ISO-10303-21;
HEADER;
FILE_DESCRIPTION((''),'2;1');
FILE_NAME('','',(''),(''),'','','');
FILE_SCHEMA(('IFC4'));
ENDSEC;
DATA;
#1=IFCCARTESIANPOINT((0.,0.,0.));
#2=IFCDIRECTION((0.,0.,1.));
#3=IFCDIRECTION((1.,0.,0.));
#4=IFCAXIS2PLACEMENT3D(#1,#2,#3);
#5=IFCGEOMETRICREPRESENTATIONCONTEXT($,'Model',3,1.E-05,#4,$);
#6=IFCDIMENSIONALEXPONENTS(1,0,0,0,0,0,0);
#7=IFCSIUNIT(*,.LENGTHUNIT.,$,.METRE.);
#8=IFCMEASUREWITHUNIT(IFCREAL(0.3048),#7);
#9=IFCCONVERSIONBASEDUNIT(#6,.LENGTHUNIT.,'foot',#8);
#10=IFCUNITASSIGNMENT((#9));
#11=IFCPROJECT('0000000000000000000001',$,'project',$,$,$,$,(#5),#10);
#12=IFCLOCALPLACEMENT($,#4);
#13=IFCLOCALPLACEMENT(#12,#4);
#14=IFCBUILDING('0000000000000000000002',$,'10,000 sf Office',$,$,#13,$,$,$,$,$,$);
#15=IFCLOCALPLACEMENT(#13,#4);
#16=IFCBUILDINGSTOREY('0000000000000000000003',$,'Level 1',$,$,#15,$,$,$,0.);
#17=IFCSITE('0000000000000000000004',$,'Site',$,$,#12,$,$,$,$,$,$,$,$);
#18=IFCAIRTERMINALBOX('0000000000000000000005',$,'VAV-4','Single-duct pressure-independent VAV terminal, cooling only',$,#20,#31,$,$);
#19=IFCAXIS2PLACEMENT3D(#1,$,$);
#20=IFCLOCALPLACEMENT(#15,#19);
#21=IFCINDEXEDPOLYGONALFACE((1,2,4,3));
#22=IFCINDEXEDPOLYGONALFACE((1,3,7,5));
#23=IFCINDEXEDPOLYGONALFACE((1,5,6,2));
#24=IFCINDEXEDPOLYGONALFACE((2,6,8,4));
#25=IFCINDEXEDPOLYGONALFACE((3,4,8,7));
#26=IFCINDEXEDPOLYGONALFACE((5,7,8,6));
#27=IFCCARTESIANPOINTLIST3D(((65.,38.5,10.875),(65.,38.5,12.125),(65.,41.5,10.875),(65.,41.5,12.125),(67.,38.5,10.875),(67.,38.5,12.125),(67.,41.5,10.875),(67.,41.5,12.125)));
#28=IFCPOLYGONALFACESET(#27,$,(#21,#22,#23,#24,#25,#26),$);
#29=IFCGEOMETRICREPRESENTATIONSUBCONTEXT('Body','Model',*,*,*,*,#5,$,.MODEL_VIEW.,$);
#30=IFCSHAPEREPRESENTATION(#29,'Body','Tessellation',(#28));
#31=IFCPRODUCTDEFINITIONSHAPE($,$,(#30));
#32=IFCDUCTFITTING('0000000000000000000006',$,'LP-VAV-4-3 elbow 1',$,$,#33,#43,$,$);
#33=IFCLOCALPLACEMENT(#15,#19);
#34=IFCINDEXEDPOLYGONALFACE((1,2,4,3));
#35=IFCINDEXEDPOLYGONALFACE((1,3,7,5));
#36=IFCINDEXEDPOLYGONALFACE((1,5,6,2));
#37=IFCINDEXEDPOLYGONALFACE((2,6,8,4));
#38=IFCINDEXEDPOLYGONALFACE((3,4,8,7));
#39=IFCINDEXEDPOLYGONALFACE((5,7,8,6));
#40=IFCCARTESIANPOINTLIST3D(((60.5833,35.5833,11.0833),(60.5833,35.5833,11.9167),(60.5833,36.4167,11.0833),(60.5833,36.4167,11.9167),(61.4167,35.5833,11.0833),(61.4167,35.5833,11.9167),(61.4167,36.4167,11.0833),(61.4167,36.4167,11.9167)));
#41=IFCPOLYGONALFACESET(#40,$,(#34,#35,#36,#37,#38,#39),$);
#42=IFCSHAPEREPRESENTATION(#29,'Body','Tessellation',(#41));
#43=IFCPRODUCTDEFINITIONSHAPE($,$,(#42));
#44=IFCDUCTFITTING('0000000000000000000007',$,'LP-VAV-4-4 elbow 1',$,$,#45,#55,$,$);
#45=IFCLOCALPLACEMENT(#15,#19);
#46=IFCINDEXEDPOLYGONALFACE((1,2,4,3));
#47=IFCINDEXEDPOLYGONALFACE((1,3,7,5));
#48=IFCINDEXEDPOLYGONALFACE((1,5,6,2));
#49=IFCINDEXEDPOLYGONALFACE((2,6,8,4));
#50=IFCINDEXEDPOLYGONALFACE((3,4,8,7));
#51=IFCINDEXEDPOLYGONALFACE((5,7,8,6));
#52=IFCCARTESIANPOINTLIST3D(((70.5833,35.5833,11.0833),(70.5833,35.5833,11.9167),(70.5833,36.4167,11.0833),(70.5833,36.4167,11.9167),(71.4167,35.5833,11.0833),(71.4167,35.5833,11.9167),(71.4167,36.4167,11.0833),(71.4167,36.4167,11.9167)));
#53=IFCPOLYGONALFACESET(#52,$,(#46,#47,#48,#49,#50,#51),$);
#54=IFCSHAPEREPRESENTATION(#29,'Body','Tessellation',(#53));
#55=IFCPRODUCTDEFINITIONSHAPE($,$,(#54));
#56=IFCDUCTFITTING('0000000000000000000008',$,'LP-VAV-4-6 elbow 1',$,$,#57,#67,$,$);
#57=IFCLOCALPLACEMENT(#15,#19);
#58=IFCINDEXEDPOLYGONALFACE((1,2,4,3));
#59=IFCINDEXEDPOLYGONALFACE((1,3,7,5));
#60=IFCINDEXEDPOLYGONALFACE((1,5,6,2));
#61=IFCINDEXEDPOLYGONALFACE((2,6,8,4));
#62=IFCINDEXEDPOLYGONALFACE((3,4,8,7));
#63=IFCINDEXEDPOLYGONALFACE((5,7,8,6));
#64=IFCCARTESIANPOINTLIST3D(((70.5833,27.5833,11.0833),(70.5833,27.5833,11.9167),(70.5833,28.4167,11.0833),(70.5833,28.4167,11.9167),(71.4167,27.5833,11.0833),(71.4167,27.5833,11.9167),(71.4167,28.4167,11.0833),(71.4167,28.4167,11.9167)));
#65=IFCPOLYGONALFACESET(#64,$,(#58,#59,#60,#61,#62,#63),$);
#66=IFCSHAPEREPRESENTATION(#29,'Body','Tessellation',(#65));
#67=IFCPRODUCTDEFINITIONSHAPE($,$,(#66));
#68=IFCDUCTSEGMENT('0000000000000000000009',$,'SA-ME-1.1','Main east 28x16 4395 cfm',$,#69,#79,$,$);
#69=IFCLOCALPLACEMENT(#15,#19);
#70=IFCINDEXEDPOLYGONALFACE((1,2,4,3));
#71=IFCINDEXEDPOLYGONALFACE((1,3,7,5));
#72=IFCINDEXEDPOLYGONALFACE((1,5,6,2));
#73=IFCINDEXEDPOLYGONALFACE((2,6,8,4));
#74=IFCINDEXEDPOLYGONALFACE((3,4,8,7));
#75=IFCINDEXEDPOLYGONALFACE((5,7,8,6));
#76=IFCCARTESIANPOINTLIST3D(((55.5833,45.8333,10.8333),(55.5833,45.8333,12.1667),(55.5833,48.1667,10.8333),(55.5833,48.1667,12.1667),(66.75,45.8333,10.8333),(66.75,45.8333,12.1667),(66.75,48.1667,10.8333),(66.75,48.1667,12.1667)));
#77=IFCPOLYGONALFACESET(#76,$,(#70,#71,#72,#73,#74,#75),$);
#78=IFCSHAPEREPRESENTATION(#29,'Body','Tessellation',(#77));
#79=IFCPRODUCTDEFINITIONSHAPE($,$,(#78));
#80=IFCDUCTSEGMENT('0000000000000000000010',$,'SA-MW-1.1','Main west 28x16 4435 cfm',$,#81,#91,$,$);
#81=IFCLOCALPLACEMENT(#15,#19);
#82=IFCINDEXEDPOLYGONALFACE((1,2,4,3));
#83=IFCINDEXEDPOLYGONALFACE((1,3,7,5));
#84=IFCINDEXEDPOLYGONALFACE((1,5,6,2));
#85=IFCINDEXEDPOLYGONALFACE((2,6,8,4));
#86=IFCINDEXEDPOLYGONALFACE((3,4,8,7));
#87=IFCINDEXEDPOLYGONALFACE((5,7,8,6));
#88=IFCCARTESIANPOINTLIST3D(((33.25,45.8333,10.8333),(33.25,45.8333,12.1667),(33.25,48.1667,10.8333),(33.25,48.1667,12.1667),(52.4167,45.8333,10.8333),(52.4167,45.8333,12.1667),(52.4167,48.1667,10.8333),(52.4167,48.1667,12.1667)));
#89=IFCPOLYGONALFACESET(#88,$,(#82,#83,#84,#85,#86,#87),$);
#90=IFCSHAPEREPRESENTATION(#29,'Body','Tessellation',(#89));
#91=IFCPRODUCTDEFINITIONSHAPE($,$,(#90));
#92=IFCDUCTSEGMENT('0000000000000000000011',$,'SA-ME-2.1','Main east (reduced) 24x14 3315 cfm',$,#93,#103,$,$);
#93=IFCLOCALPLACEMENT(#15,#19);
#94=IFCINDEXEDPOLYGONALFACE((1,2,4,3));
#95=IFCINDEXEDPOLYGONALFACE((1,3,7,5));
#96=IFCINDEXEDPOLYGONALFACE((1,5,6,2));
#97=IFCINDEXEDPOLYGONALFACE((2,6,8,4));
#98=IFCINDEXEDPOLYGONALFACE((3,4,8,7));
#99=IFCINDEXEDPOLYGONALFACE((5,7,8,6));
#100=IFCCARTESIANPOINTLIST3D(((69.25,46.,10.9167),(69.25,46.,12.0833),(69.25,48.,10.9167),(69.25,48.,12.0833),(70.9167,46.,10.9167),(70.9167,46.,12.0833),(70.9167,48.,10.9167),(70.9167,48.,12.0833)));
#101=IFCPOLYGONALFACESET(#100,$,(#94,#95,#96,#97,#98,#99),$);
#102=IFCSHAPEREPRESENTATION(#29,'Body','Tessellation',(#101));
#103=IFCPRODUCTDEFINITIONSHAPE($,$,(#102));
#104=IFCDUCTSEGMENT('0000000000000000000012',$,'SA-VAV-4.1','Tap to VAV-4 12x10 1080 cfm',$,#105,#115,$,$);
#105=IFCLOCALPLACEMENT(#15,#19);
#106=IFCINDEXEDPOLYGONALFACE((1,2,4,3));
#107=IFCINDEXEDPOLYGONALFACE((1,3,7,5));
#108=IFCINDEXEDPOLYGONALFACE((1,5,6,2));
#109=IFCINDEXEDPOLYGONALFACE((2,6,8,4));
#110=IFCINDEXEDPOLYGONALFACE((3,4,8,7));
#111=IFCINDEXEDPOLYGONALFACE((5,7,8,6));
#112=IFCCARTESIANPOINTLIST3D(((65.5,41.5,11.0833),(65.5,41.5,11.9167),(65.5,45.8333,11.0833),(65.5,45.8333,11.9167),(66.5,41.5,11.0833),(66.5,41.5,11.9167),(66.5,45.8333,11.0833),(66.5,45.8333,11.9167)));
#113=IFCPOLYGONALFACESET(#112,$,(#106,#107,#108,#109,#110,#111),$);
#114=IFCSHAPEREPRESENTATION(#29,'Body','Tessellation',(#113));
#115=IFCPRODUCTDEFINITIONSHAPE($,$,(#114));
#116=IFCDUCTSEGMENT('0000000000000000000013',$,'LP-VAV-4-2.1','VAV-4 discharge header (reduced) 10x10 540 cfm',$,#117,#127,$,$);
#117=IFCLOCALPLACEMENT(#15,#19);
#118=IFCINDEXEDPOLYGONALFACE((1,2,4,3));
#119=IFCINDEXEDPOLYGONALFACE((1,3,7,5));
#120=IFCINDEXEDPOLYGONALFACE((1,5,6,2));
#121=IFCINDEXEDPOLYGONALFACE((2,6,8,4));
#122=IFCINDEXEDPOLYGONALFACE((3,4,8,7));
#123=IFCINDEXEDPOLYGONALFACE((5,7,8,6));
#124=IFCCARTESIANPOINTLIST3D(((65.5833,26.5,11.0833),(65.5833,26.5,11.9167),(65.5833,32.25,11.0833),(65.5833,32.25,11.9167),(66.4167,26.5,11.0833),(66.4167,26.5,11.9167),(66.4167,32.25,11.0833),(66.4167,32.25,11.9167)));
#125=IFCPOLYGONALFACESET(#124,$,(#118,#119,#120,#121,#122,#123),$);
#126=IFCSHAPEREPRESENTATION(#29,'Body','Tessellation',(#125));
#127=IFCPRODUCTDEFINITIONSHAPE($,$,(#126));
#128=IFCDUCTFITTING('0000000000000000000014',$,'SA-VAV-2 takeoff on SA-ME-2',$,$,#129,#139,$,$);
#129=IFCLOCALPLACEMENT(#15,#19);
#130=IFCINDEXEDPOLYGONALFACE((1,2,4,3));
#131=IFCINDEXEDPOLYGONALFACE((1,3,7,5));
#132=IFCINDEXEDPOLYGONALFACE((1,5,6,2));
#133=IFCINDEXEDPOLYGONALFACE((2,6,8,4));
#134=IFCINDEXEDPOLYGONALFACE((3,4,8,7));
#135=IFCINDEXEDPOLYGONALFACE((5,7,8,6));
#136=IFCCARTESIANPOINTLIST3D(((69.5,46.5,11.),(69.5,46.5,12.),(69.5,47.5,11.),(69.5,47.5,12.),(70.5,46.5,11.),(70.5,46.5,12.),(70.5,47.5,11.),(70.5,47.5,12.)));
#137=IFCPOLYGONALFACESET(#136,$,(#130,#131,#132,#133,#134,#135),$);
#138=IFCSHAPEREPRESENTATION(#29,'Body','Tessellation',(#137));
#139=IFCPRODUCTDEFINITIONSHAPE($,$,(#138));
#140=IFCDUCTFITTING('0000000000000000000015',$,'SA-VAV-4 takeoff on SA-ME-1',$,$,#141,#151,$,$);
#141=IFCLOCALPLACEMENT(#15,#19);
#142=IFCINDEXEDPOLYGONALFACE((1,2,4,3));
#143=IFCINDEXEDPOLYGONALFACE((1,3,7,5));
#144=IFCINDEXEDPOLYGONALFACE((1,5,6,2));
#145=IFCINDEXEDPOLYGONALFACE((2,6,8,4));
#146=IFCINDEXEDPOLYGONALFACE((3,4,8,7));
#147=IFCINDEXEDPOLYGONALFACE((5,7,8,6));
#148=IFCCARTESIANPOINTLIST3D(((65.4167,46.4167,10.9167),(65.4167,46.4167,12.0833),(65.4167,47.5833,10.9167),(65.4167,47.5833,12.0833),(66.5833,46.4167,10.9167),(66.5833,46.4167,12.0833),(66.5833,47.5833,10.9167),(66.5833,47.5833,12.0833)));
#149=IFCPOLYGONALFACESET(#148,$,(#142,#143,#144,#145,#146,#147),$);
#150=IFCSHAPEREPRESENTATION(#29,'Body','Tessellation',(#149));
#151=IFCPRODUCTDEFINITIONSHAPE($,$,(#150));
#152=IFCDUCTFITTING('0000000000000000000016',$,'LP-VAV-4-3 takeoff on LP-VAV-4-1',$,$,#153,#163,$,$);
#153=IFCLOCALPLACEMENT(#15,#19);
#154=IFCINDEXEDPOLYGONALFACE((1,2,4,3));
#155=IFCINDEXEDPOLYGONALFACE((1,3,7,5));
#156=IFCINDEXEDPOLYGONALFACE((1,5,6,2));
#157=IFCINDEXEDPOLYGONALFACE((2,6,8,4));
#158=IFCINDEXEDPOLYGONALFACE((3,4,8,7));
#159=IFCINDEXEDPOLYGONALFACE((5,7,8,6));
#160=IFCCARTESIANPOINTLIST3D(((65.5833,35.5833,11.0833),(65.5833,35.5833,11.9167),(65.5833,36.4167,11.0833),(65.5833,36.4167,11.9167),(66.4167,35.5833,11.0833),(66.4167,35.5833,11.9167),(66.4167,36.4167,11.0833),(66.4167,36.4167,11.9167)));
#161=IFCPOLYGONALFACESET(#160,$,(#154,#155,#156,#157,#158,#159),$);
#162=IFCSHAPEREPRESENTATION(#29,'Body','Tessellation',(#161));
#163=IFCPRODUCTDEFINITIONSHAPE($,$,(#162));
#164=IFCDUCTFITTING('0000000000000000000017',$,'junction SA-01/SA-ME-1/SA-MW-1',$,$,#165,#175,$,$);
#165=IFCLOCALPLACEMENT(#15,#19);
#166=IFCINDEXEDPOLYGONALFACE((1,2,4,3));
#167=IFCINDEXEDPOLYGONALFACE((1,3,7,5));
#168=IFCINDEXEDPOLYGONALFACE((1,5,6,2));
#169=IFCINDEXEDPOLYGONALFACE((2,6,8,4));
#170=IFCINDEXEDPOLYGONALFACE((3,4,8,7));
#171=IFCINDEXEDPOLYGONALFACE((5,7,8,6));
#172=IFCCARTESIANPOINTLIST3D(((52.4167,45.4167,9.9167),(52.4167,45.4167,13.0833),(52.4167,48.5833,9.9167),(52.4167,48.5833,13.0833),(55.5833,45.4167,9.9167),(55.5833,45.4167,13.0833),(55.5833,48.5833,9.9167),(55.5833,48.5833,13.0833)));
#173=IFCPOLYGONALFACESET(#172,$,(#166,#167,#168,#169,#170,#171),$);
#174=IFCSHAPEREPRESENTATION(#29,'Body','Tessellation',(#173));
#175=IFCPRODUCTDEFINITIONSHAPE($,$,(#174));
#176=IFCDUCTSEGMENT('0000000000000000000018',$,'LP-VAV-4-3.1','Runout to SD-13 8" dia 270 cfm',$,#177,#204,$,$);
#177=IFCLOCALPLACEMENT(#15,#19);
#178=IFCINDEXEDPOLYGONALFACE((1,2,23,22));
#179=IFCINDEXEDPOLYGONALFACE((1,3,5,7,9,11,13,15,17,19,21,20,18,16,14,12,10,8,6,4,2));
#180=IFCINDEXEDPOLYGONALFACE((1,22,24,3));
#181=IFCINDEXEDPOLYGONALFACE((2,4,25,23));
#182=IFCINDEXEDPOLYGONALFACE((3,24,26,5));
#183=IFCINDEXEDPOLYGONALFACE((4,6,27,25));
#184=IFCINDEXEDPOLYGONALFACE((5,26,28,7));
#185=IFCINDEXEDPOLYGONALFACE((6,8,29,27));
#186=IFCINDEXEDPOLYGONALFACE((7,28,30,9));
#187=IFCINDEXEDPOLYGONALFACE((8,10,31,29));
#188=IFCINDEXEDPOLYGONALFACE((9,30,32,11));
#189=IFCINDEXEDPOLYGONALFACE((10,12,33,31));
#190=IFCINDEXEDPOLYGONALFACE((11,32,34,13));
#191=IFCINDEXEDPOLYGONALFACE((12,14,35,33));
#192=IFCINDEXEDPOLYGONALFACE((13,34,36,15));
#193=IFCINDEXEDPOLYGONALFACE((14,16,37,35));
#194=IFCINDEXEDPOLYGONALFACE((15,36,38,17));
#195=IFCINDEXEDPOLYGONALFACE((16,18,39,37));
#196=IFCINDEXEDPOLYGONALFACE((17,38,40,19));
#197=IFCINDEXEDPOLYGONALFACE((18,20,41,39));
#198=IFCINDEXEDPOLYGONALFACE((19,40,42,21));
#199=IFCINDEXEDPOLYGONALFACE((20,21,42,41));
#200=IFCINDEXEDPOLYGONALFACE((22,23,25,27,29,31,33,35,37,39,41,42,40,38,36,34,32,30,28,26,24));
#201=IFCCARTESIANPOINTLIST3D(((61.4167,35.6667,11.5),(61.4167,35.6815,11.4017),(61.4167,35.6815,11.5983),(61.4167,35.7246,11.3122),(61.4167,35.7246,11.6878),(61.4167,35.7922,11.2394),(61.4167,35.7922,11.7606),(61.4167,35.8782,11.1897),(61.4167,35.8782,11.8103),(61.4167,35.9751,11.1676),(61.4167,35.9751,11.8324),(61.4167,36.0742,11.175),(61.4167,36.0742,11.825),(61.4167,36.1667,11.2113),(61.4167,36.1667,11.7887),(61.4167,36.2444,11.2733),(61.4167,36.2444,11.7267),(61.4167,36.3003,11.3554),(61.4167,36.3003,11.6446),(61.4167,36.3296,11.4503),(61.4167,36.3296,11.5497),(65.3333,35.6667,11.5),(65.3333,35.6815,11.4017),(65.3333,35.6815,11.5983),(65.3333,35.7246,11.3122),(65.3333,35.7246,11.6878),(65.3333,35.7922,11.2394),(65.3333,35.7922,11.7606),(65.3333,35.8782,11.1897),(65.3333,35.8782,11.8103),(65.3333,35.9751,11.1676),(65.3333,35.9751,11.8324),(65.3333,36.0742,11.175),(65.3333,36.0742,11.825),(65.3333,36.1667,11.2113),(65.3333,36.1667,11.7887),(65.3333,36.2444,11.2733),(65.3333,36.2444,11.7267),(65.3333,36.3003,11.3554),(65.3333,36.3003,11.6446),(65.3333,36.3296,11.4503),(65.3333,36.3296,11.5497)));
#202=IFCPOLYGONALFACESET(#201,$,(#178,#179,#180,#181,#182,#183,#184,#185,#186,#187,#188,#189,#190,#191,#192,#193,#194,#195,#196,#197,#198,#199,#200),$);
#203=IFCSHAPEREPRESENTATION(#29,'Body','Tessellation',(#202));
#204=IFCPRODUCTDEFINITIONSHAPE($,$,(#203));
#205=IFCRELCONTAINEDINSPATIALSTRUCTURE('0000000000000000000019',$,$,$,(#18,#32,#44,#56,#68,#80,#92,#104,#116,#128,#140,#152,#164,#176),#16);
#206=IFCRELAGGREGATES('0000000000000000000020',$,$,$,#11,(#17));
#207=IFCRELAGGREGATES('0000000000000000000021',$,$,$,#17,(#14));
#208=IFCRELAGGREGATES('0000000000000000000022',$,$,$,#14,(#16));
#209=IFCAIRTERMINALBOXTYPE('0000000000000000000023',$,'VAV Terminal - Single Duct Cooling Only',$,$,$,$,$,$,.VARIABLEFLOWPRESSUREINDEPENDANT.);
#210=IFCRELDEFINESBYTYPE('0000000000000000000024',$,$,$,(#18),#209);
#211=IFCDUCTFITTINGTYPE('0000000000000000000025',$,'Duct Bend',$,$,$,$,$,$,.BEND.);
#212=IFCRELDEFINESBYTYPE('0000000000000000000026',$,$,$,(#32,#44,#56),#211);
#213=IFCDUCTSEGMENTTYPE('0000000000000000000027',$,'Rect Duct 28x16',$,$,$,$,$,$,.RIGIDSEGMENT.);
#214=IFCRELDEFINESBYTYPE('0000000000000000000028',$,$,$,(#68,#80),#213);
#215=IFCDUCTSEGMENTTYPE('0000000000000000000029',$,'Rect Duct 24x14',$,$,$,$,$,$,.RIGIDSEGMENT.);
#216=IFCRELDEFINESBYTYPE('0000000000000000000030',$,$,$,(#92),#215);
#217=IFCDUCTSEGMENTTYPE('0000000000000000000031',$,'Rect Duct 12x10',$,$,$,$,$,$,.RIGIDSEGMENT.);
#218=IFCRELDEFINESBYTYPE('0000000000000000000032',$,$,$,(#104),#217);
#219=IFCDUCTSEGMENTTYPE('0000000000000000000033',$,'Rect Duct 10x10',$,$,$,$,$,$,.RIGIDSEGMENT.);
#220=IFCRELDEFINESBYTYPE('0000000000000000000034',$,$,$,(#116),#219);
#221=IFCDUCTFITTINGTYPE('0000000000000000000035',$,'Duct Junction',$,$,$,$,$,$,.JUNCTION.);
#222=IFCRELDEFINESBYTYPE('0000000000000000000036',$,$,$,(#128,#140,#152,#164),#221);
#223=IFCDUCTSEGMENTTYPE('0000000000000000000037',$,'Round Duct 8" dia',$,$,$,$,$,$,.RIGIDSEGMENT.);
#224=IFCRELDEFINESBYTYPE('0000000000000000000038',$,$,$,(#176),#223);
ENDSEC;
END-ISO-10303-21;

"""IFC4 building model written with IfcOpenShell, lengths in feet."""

from ifc_helpers import new_model, entity, si_unit, converted_unit, frame, origin_with_axes, place, context, subcontext, project, spatial, rectangle, circle, extrude, type_object, element, save


model = new_model("IFC4")

# Units and contexts
model_context = context("Model", 3, precision=1e-05, world=origin_with_axes())
body_context = subcontext(model_context, "Body", "Model", "MODEL_VIEW")
ifc_project = project(units=[converted_unit("LENGTHUNIT", "foot", entity("IfcReal", 0.3048), si_unit("LENGTHUNIT", "METRE"), dimensions=[1, 0, 0, 0, 0, 0, 0])], contexts=[model_context])

# Site, building, storey
site_placement = place(None, origin_with_axes())
site = spatial("IfcSite", under=ifc_project, at=site_placement, Name="Site")
building_placement = place(site_placement, origin_with_axes())
building = spatial("IfcBuilding", under=site, at=building_placement, Name="10,000 sf Office")
storey_placement = place(building_placement, origin_with_axes())
storey = spatial("IfcBuildingStorey", under=building, at=storey_placement, Name="Level 1", Elevation=0.0)

# Air terminal box
air_terminal_box_type = type_object("IfcAirTerminalBoxType", Name="VAV Terminal - Single Duct Cooling Only", PredefinedType="VARIABLEFLOWPRESSUREINDEPENDANT")
air_terminal_box_placement = place(storey_placement, frame((66.0, 40.0, 10.875), z_axis=(0.0, 0.0, 1.0), x_axis=(0.0, -1.0, 0.0)))
element("IfcAirTerminalBox", 1, at=air_terminal_box_placement, inside=storey, type_object=air_terminal_box_type, Name="VAV-4", Description="Single-duct pressure-independent VAV terminal, cooling only", context=body_context, shape_type="SweptSolid", body=[
    extrude(rectangle(XDim=3.0, YDim=2.0), None, (0.0, 0.0, 1.0), 1.25),
])

# Duct fittings
duct_fitting_type_1 = type_object("IfcDuctFittingType", Name="Duct Bend", PredefinedType="BEND")
for number, where, z_axis, x_axis, name in (
    (2, (61.0, 36.0, 11.0833), (0.0, 0.0, 1.0), (1.0, 0.0, 0.0), "LP-VAV-4-3 elbow 1"),
    (3, (71.0, 36.0, 11.0833), (0.0, 0.0, 1.0), (1.0, 0.0, 0.0), "LP-VAV-4-4 elbow 1"),
    (4, (71.0, 28.0, 11.0833), (0.0, 0.0, 1.0), (1.0, 0.0, 0.0), "LP-VAV-4-6 elbow 1"),
):
    element("IfcDuctFitting", number, at=place(storey_placement, frame(where, z_axis=z_axis, x_axis=x_axis)), inside=storey, type_object=duct_fitting_type_1, Name=name, context=body_context, shape_type="SweptSolid", body=[
        extrude(rectangle(XDim=0.8333, YDim=0.8333), None, (0.0, 0.0, 1.0), 0.8333),
    ])

# Duct segments
duct_segment_type_1 = type_object("IfcDuctSegmentType", Name="Rect Duct 28x16", PredefinedType="RIGIDSEGMENT")
duct_segment_1_placement = place(storey_placement, frame((55.5833, 47.0, 11.5), z_axis=(1.0, 0.0, 0.0), x_axis=(0.0, 1.0, 0.0)))
element("IfcDuctSegment", 5, at=duct_segment_1_placement, inside=storey, type_object=duct_segment_type_1, Name="SA-ME-1.1", Description="Main east 28x16 4395 cfm", context=body_context, shape_type="SweptSolid", body=[
    extrude(rectangle(XDim=2.3333, YDim=1.3333), None, (0.0, 0.0, 1.0), 11.1667),
])
duct_segment_2_placement = place(storey_placement, frame((52.4167, 47.0, 11.5), z_axis=(-1.0, 0.0, 0.0), x_axis=(0.0, -1.0, 0.0)))
element("IfcDuctSegment", 6, at=duct_segment_2_placement, inside=storey, type_object=duct_segment_type_1, Name="SA-MW-1.1", Description="Main west 28x16 4435 cfm", context=body_context, shape_type="SweptSolid", body=[
    extrude(rectangle(XDim=2.3333, YDim=1.3333), None, (0.0, 0.0, 1.0), 19.1667),
])
duct_segment_type_2 = type_object("IfcDuctSegmentType", Name="Rect Duct 24x14", PredefinedType="RIGIDSEGMENT")
duct_segment_3_placement = place(storey_placement, frame((69.25, 47.0, 11.5), z_axis=(1.0, 0.0, 0.0), x_axis=(0.0, 1.0, 0.0)))
element("IfcDuctSegment", 7, at=duct_segment_3_placement, inside=storey, type_object=duct_segment_type_2, Name="SA-ME-2.1", Description="Main east (reduced) 24x14 3315 cfm", context=body_context, shape_type="SweptSolid", body=[
    extrude(rectangle(XDim=2.0, YDim=1.1667), None, (0.0, 0.0, 1.0), 1.6667),
])
duct_segment_type_3 = type_object("IfcDuctSegmentType", Name="Rect Duct 12x10", PredefinedType="RIGIDSEGMENT")
duct_segment_4_placement = place(storey_placement, frame((66.0, 45.8333, 11.5), z_axis=(0.0, -1.0, 0.0), x_axis=(1.0, 0.0, 0.0)))
element("IfcDuctSegment", 8, at=duct_segment_4_placement, inside=storey, type_object=duct_segment_type_3, Name="SA-VAV-4.1", Description="Tap to VAV-4 12x10 1080 cfm", context=body_context, shape_type="SweptSolid", body=[
    extrude(rectangle(XDim=1.0, YDim=0.8333), None, (0.0, 0.0, 1.0), 4.3333),
])
duct_segment_type_4 = type_object("IfcDuctSegmentType", Name="Rect Duct 10x10", PredefinedType="RIGIDSEGMENT")
duct_segment_5_placement = place(storey_placement, frame((66.0, 32.25, 11.5), z_axis=(0.0, -1.0, 0.0), x_axis=(1.0, 0.0, 0.0)))
element("IfcDuctSegment", 9, at=duct_segment_5_placement, inside=storey, type_object=duct_segment_type_4, Name="LP-VAV-4-2.1", Description="VAV-4 discharge header (reduced) 10x10 540 cfm", context=body_context, shape_type="SweptSolid", body=[
    extrude(rectangle(XDim=0.8333, YDim=0.8333), None, (0.0, 0.0, 1.0), 5.75),
])

# Duct fittings
duct_fitting_type_2 = type_object("IfcDuctFittingType", Name="Duct Junction", PredefinedType="JUNCTION")
duct_fitting_1_placement = place(storey_placement, frame((70.0, 47.0, 11.0), z_axis=(0.0, 0.0, 1.0), x_axis=(1.0, 0.0, 0.0)))
element("IfcDuctFitting", 10, at=duct_fitting_1_placement, inside=storey, type_object=duct_fitting_type_2, Name="SA-VAV-2 takeoff on SA-ME-2", context=body_context, shape_type="SweptSolid", body=[
    extrude(rectangle(XDim=1.0, YDim=1.0), None, (0.0, 0.0, 1.0), 1.0),
])
duct_fitting_2_placement = place(storey_placement, frame((66.0, 47.0, 10.9167), z_axis=(0.0, 0.0, 1.0), x_axis=(1.0, 0.0, 0.0)))
element("IfcDuctFitting", 11, at=duct_fitting_2_placement, inside=storey, type_object=duct_fitting_type_2, Name="SA-VAV-4 takeoff on SA-ME-1", context=body_context, shape_type="SweptSolid", body=[
    extrude(rectangle(XDim=1.1667, YDim=1.1667), None, (0.0, 0.0, 1.0), 1.1667),
])
for number, where, z_axis, x_axis, name in (
    (12, (66.0, 36.0, 11.0833), (0.0, 0.0, 1.0), (1.0, 0.0, 0.0), "LP-VAV-4-3 takeoff on LP-VAV-4-1"),
):
    element("IfcDuctFitting", number, at=place(storey_placement, frame(where, z_axis=z_axis, x_axis=x_axis)), inside=storey, type_object=duct_fitting_type_2, Name=name, context=body_context, shape_type="SweptSolid", body=[
        extrude(rectangle(XDim=0.8333, YDim=0.8333), None, (0.0, 0.0, 1.0), 0.8333),
    ])
duct_fitting_3_placement = place(storey_placement, frame((54.0, 47.0, 9.9167), z_axis=(0.0, 0.0, 1.0), x_axis=(1.0, 0.0, 0.0)))
element("IfcDuctFitting", 13, at=duct_fitting_3_placement, inside=storey, type_object=duct_fitting_type_2, Name="junction SA-01/SA-ME-1/SA-MW-1", context=body_context, shape_type="SweptSolid", body=[
    extrude(rectangle(XDim=3.1667, YDim=3.1667), None, (0.0, 0.0, 1.0), 3.1667),
])

# Duct segment
duct_segment_type_5 = type_object("IfcDuctSegmentType", Name="Round Duct 8\" dia", PredefinedType="RIGIDSEGMENT")
duct_segment_6_placement = place(storey_placement, frame((65.3333, 36.0, 11.5), z_axis=(-1.0, 0.0, 0.0), x_axis=(0.0, -1.0, 0.0)))
element("IfcDuctSegment", 14, at=duct_segment_6_placement, inside=storey, type_object=duct_segment_type_5, Name="LP-VAV-4-3.1", Description="Runout to SD-13 8\" dia 270 cfm", context=body_context, shape_type="SweptSolid", body=[
    extrude(circle(Radius=0.3333), None, (0.0, 0.0, 1.0), 3.9167),
])

save(model, "model.ifc")
